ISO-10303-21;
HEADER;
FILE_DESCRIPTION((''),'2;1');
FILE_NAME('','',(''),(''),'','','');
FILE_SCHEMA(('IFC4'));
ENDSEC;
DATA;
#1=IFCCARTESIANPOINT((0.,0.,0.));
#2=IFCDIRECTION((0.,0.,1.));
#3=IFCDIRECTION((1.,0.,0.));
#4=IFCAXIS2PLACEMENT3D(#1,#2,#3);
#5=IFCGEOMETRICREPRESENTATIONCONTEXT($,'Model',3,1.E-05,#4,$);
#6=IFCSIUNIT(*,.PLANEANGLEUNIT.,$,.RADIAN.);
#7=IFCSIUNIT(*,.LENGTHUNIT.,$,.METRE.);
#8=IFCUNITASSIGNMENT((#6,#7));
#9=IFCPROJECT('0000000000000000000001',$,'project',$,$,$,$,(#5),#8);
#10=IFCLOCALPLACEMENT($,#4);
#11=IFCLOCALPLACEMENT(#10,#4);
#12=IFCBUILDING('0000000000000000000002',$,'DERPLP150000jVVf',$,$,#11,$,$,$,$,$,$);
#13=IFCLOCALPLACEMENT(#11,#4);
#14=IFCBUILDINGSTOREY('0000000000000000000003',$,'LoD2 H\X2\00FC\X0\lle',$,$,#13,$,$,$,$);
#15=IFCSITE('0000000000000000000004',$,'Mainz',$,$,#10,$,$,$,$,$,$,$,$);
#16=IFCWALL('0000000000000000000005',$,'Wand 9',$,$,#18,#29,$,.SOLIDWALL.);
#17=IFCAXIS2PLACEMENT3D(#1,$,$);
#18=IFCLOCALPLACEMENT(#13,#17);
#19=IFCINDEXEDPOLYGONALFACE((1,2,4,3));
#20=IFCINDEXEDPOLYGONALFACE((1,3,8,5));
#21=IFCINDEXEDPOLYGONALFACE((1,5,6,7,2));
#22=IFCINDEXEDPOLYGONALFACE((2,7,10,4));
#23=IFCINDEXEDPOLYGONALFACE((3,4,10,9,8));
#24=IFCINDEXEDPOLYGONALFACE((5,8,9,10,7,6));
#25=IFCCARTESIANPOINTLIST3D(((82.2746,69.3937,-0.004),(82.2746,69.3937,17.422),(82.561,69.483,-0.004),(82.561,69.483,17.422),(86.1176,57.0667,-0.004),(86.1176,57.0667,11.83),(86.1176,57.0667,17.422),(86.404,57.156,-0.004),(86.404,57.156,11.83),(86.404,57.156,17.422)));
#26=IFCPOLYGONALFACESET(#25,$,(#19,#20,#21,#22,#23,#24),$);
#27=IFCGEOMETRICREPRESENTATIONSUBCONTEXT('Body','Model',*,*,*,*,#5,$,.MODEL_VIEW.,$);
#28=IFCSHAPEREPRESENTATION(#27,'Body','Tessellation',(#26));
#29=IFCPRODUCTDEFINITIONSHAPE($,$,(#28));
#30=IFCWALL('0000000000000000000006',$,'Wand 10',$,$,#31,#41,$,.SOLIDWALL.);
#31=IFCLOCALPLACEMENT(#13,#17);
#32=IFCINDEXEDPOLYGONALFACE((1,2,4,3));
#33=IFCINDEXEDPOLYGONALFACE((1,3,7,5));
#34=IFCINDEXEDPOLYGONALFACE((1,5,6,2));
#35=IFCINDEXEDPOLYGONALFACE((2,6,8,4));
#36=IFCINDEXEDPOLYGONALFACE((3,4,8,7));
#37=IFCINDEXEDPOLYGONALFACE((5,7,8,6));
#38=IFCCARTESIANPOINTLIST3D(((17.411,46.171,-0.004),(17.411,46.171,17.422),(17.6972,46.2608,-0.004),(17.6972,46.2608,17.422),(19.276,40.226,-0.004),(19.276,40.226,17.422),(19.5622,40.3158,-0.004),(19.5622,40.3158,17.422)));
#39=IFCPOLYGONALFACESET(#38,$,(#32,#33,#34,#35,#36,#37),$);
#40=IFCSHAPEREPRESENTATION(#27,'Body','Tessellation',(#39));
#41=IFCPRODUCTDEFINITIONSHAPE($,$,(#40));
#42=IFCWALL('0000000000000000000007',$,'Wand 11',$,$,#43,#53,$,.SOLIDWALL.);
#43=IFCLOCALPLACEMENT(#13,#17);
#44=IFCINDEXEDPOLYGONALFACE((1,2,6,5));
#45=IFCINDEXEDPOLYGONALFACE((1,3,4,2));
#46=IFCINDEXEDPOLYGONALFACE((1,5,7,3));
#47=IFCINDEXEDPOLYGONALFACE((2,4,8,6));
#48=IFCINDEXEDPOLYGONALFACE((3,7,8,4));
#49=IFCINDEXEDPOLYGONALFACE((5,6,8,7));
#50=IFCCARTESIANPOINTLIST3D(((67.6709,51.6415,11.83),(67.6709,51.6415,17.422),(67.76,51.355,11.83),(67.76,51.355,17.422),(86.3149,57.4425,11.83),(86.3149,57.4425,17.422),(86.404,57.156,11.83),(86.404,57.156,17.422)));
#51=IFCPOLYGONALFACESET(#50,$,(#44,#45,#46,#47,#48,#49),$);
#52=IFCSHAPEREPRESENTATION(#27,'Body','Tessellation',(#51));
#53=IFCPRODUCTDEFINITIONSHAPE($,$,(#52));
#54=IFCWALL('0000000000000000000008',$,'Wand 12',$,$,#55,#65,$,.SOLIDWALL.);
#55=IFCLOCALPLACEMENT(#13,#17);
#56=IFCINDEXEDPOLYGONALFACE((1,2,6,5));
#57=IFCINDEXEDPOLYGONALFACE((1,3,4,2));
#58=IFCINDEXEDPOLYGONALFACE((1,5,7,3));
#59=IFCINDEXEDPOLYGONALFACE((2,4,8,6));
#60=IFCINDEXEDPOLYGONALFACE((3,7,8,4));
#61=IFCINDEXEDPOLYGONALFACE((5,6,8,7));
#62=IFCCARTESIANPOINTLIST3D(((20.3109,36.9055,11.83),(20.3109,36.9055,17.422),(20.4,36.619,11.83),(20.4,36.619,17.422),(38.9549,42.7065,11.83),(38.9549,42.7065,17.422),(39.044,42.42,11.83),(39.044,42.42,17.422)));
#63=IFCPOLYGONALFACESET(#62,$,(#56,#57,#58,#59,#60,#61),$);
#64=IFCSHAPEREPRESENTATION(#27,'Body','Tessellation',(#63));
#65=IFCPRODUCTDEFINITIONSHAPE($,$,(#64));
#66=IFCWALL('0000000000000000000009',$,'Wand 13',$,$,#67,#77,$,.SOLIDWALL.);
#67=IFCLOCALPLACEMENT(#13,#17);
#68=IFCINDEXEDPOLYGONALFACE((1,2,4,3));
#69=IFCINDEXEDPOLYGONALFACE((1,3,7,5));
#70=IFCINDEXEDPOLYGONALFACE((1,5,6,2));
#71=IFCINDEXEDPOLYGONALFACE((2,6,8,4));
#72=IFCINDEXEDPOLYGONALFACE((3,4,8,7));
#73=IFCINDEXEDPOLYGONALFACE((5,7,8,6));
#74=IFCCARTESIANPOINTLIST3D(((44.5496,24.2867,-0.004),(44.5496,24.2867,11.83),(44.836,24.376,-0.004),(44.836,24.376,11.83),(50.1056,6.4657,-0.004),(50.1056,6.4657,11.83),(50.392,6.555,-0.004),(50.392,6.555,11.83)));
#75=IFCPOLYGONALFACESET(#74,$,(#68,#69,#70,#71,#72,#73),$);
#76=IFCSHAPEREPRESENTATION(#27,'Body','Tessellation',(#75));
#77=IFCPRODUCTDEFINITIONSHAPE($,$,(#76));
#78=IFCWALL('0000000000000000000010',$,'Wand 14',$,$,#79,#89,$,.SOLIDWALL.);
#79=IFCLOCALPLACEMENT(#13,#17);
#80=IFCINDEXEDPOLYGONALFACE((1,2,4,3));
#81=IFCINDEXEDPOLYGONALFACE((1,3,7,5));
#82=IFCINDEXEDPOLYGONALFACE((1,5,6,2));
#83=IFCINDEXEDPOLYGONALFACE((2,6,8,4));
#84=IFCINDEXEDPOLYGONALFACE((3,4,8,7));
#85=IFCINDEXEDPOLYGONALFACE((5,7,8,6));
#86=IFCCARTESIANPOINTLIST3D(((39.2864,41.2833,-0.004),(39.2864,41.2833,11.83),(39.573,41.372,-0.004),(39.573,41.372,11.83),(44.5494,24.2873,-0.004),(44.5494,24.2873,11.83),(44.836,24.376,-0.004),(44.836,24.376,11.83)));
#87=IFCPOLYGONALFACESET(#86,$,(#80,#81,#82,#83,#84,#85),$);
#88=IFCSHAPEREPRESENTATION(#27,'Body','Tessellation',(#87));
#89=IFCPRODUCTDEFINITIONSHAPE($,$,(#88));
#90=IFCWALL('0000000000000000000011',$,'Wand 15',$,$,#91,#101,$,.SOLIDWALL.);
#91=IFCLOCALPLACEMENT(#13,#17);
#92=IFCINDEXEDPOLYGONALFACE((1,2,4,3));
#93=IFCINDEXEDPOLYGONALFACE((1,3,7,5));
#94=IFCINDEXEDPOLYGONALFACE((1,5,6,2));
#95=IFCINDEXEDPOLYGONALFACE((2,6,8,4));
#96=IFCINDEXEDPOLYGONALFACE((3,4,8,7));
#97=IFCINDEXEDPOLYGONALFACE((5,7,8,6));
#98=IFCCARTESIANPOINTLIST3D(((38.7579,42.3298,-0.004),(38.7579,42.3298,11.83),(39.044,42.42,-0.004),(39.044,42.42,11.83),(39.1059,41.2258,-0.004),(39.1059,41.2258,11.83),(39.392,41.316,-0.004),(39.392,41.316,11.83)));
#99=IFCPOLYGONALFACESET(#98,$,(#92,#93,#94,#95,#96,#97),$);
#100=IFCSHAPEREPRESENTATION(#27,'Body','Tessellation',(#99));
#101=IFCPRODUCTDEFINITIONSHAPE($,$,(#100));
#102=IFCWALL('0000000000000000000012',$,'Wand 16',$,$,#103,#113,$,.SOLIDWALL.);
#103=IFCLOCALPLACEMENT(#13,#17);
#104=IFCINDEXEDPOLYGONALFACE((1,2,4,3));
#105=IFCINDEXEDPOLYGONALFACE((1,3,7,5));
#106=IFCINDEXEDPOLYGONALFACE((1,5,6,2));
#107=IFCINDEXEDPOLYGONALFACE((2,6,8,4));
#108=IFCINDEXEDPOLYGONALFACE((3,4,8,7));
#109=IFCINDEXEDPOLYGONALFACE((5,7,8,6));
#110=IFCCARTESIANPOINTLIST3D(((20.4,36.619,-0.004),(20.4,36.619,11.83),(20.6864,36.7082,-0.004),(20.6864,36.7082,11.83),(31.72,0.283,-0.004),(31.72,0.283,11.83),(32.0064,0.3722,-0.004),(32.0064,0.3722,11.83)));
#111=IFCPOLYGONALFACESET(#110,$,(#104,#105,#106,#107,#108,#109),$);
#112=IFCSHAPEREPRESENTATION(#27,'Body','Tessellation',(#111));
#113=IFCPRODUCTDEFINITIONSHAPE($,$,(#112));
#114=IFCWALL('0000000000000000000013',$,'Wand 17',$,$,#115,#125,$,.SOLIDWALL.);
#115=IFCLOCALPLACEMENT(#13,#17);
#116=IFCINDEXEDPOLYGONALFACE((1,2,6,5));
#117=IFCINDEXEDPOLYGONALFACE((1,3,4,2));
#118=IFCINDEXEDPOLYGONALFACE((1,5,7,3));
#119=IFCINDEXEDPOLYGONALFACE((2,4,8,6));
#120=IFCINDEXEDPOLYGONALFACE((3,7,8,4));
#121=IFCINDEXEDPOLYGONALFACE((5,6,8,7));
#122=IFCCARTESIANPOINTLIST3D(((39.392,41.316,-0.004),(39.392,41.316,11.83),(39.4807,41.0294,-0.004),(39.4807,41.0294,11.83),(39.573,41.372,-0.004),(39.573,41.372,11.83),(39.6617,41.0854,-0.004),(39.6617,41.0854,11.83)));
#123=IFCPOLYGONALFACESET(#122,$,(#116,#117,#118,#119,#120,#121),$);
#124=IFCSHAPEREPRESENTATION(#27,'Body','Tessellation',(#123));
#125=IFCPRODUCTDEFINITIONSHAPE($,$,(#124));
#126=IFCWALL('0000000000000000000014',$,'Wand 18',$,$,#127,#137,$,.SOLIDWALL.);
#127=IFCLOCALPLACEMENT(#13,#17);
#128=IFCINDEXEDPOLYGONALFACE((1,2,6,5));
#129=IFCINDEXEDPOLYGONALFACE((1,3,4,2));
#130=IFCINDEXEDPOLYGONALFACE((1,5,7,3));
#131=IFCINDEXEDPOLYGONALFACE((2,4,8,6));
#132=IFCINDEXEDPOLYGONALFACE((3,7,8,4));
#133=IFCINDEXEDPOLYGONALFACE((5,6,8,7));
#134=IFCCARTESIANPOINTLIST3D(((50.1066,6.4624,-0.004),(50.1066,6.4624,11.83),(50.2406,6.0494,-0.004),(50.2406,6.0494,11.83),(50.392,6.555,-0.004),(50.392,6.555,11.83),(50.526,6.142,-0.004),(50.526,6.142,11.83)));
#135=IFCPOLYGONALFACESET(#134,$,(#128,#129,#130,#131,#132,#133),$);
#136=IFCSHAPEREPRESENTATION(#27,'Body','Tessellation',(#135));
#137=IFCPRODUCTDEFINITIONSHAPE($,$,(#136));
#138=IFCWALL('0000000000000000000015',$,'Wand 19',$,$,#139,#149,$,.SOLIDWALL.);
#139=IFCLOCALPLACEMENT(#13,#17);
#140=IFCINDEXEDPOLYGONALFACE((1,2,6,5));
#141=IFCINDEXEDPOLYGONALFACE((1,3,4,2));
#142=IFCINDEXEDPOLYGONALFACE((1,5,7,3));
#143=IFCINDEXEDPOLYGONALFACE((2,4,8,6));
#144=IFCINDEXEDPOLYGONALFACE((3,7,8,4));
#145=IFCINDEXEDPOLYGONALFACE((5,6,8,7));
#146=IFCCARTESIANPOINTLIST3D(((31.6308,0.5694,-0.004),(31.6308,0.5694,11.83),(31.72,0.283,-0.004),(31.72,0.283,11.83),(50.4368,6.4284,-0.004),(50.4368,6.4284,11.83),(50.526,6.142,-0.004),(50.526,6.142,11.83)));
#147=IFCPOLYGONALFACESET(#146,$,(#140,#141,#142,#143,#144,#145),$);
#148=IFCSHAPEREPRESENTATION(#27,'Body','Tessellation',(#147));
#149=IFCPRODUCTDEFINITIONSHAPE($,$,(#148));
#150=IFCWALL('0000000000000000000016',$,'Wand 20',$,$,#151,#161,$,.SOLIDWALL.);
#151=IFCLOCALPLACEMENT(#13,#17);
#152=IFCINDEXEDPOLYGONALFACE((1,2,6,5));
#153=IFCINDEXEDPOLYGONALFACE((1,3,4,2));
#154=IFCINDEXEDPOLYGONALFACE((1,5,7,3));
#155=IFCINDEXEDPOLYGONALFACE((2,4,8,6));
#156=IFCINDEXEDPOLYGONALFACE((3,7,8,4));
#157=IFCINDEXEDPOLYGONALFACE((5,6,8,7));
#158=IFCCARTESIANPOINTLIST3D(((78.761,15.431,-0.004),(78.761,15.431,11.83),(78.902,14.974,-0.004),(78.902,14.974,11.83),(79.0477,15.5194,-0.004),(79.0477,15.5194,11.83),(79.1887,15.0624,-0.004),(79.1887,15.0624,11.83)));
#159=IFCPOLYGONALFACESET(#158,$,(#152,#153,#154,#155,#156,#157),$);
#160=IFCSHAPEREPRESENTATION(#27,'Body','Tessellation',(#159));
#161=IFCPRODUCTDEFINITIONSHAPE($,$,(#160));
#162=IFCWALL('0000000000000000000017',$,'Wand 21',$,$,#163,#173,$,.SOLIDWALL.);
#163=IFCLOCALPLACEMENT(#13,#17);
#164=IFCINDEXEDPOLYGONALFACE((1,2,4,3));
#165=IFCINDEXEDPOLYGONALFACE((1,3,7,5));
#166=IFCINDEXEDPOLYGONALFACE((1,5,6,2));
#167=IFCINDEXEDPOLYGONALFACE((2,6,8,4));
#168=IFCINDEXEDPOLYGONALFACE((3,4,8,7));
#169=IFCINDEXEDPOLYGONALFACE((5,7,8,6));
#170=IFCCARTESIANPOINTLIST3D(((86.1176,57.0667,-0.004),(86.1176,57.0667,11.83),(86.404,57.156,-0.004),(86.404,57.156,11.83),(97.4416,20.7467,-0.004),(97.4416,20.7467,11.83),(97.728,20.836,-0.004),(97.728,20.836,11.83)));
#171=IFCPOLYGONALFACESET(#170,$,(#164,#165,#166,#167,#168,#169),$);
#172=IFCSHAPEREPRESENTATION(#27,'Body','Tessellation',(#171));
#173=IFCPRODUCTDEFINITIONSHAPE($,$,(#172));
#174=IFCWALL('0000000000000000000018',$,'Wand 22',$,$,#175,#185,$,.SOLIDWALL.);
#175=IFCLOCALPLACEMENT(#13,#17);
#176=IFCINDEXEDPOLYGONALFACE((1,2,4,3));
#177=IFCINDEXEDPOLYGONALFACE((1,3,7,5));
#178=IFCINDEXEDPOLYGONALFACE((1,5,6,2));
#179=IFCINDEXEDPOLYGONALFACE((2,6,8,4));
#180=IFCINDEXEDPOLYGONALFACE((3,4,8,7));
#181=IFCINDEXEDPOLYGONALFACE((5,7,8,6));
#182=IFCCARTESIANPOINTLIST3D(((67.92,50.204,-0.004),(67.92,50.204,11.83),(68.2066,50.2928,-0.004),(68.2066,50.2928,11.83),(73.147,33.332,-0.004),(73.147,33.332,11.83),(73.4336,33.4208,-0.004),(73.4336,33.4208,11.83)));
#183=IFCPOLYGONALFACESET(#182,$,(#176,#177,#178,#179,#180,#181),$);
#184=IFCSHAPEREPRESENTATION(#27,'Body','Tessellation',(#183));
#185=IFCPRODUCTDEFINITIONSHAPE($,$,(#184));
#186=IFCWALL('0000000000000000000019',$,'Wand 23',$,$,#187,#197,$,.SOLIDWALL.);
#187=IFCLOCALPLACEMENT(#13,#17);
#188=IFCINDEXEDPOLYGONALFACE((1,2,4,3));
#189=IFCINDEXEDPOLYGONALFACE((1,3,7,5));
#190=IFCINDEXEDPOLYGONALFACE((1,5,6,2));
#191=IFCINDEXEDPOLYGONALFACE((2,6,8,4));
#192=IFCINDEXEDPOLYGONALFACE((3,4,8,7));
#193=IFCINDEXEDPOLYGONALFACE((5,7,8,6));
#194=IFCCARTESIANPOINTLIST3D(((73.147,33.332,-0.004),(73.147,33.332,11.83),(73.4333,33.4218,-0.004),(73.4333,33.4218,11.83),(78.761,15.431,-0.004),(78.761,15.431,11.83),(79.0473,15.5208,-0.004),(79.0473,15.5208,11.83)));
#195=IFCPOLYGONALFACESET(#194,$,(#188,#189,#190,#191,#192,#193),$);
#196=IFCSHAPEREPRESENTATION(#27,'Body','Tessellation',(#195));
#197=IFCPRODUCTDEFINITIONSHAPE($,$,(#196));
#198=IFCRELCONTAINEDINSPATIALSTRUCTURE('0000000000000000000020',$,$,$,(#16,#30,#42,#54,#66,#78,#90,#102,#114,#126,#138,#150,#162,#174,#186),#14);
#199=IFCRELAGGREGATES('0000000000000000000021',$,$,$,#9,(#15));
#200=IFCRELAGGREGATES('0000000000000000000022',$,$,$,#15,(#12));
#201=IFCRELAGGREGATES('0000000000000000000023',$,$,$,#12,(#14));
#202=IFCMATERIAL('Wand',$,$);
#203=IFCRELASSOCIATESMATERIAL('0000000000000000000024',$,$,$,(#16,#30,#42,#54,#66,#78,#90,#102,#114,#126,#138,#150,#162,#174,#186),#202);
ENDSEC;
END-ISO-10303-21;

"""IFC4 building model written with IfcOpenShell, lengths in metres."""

from ifc_helpers import new_model, si_unit, frame, origin_with_axes, place, context, subcontext, project, spatial, polyline, outline, extrude, material, element, save


model = new_model("IFC4")

# Units and contexts
model_context = context("Model", 3, precision=1e-05, world=origin_with_axes())
body_context = subcontext(model_context, "Body", "Model", "MODEL_VIEW")
ifc_project = project(units=[si_unit("PLANEANGLEUNIT", "RADIAN"), si_unit("LENGTHUNIT", "METRE")], contexts=[model_context])

# Site, building, storey
site_placement = place(None, origin_with_axes())
site = spatial("IfcSite", under=ifc_project, at=site_placement, Name="Mainz")
building_placement = place(site_placement, origin_with_axes())
building = spatial("IfcBuilding", under=site, at=building_placement, Name="DERPLP150000jVVf")
storey_placement = place(building_placement, origin_with_axes())
storey = spatial("IfcBuildingStorey", under=building, at=storey_placement, Name="LoD2 Hülle")

# Walls
ifc_material_1 = material(Name="Wand")
wall_1_placement = place(storey_placement, origin_with_axes())
element("IfcWall", 1, at=wall_1_placement, inside=storey, material=ifc_material_1, Name="Wand 9", PredefinedType="SOLIDWALL", context=body_context, shape_type="SweptSolid", body=[
    extrude(outline(polyline([(0.0, 0.0), (12.9121, 0.0), (12.9121, 5.592), (12.9121, 17.426), (0.0, 17.426), (0.0, 0.0)])), frame((82.561, 69.483, 17.422), z_axis=(0.954682, 0.297627, 0.0), x_axis=(0.297627, -0.954682, 0.0)), (0.0, 0.0, -1.0), 0.3),
])
wall_2_placement = place(storey_placement, origin_with_axes())
element("IfcWall", 2, at=wall_2_placement, inside=storey, material=ifc_material_1, Name="Wand 10", PredefinedType="SOLIDWALL", context=body_context, shape_type="SweptSolid", body=[
    extrude(outline(polyline([(0.0, 0.0), (6.2307, 0.0), (6.2307, 17.426), (0.0, 17.426), (0.0, 0.0)])), frame((19.276, 40.226, 17.422), z_axis=(-0.954151, -0.299326, 0.0), x_axis=(-0.299326, 0.954151, 0.0)), (0.0, 0.0, -1.0), 0.3),
])
wall_3_placement = place(storey_placement, origin_with_axes())
element("IfcWall", 3, at=wall_3_placement, inside=storey, material=ifc_material_1, Name="Wand 11", PredefinedType="SOLIDWALL", context=body_context, shape_type="SweptSolid", body=[
    extrude(outline(polyline([(0.0, 0.0), (19.5256, 0.0), (19.5256, 5.592), (0.0, 5.592), (0.0, 0.0)])), frame((67.76, 51.355, 11.83), z_axis=(0.297097, -0.954847, 0.0), x_axis=(0.954847, 0.297097, 0.0)), (0.0, 0.0, -1.0), 0.3),
])
wall_4_placement = place(storey_placement, origin_with_axes())
element("IfcWall", 4, at=wall_4_placement, inside=storey, material=ifc_material_1, Name="Wand 12", PredefinedType="SOLIDWALL", context=body_context, shape_type="SweptSolid", body=[
    extrude(outline(polyline([(0.0, 0.0), (19.5256, 0.0), (19.5256, 5.592), (0.0, 5.592), (0.0, 0.0)])), frame((20.4, 36.619, 11.83), z_axis=(0.297097, -0.954847, 0.0), x_axis=(0.954847, 0.297097, 0.0)), (0.0, 0.0, -1.0), 0.3),
])
wall_5_placement = place(storey_placement, origin_with_axes())
element("IfcWall", 5, at=wall_5_placement, inside=storey, material=ifc_material_1, Name="Wand 13", PredefinedType="SOLIDWALL", context=body_context, shape_type="SweptSolid", body=[
    extrude(outline(polyline([(0.0, 0.0), (18.667, 0.0), (18.667, 11.834), (0.0, 11.834), (0.0, 0.0)])), frame((44.836, 24.376, 11.83), z_axis=(0.954679, 0.297637, 0.0), x_axis=(0.297637, -0.954679, 0.0)), (0.0, 0.0, -1.0), 0.3),
])
wall_6_placement = place(storey_placement, origin_with_axes())
element("IfcWall", 6, at=wall_6_placement, inside=storey, material=ifc_material_1, Name="Wand 14", PredefinedType="SOLIDWALL", context=body_context, shape_type="SweptSolid", body=[
    extrude(outline(polyline([(0.0, 0.0), (17.7922, 0.0), (17.7922, 11.834), (0.0, 11.834), (0.0, 0.0)])), frame((39.573, 41.372, 11.83), z_axis=(0.955249, 0.295803, 0.0), x_axis=(0.295803, -0.955249, 0.0)), (0.0, 0.0, -1.0), 0.3),
])
wall_7_placement = place(storey_placement, origin_with_axes())
element("IfcWall", 7, at=wall_7_placement, inside=storey, material=ifc_material_1, Name="Wand 15", PredefinedType="SOLIDWALL", context=body_context, shape_type="SweptSolid", body=[
    extrude(outline(polyline([(0.0, 0.0), (1.1575, 0.0), (1.1575, 11.834), (0.0, 11.834), (0.0, 0.0)])), frame((39.044, 42.42, 11.83), z_axis=(0.953739, 0.300635, 0.0), x_axis=(0.300635, -0.953739, 0.0)), (0.0, 0.0, -1.0), 0.3),
])
wall_8_placement = place(storey_placement, origin_with_axes())
element("IfcWall", 8, at=wall_8_placement, inside=storey, material=ifc_material_1, Name="Wand 16", PredefinedType="SOLIDWALL", context=body_context, shape_type="SweptSolid", body=[
    extrude(outline(polyline([(0.0, 0.0), (38.0585, 0.0), (38.0585, 11.834), (0.0, 11.834), (0.0, 0.0)])), frame((31.72, 0.283, 11.83), z_axis=(-0.954741, -0.297437, 0.0), x_axis=(-0.297437, 0.954741, 0.0)), (0.0, 0.0, -1.0), 0.3),
])
wall_9_placement = place(storey_placement, origin_with_axes())
element("IfcWall", 9, at=wall_9_placement, inside=storey, material=ifc_material_1, Name="Wand 17", PredefinedType="SOLIDWALL", context=body_context, shape_type="SweptSolid", body=[
    extrude(outline(polyline([(0.0, 0.0), (0.1895, 0.0), (0.1895, 11.834), (0.0, 11.834), (0.0, 0.0)])), frame((39.392, 41.316, 11.83), z_axis=(-0.295569, 0.955321, 0.0), x_axis=(0.955321, 0.295569, 0.0)), (0.0, 0.0, -1.0), 0.3),
])
wall_10_placement = place(storey_placement, origin_with_axes())
element("IfcWall", 10, at=wall_10_placement, inside=storey, material=ifc_material_1, Name="Wand 18", PredefinedType="SOLIDWALL", context=body_context, shape_type="SweptSolid", body=[
    extrude(outline(polyline([(0.0, 0.0), (0.4342, 0.0), (0.4342, 11.834), (0.0, 11.834), (0.0, 0.0)])), frame((50.392, 6.555, 11.83), z_axis=(0.951186, 0.308617, 0.0), x_axis=(0.308617, -0.951186, 0.0)), (0.0, 0.0, -1.0), 0.3),
])
wall_11_placement = place(storey_placement, origin_with_axes())
element("IfcWall", 11, at=wall_11_placement, inside=storey, material=ifc_material_1, Name="Wand 19", PredefinedType="SOLIDWALL", context=body_context, shape_type="SweptSolid", body=[
    extrude(outline(polyline([(0.0, 0.0), (19.6976, 0.0), (19.6976, 11.834), (0.0, 11.834), (0.0, 0.0)])), frame((50.526, 6.142, 11.83), z_axis=(0.297448, -0.954738, 0.0), x_axis=(-0.954738, -0.297448, 0.0)), (0.0, 0.0, -1.0), 0.3),
])
wall_12_placement = place(storey_placement, origin_with_axes())
element("IfcWall", 12, at=wall_12_placement, inside=storey, material=ifc_material_1, Name="Wand 20", PredefinedType="SOLIDWALL", context=body_context, shape_type="SweptSolid", body=[
    extrude(outline(polyline([(0.0, 0.0), (0.4783, 0.0), (0.4783, 11.834), (0.0, 11.834), (0.0, 0.0)])), frame((78.902, 14.974, 11.83), z_axis=(-0.955553, -0.29482, 0.0), x_axis=(-0.29482, 0.955553, 0.0)), (0.0, 0.0, -1.0), 0.3),
])
wall_13_placement = place(storey_placement, origin_with_axes())
element("IfcWall", 13, at=wall_13_placement, inside=storey, material=ifc_material_1, Name="Wand 21", PredefinedType="SOLIDWALL", context=body_context, shape_type="SweptSolid", body=[
    extrude(outline(polyline([(0.0, 0.0), (38.0444, 0.0), (38.0444, 11.834), (0.0, 11.834), (0.0, 0.0)])), frame((86.404, 57.156, 11.83), z_axis=(0.954674, 0.297652, 0.0), x_axis=(0.297652, -0.954674, 0.0)), (0.0, 0.0, -1.0), 0.3),
])
wall_14_placement = place(storey_placement, origin_with_axes())
element("IfcWall", 14, at=wall_14_placement, inside=storey, material=ifc_material_1, Name="Wand 22", PredefinedType="SOLIDWALL", context=body_context, shape_type="SweptSolid", body=[
    extrude(outline(polyline([(0.0, 0.0), (17.6631, 0.0), (17.6631, 11.834), (0.0, 11.834), (0.0, 0.0)])), frame((73.147, 33.332, 11.83), z_axis=(-0.95521, -0.295927, 0.0), x_axis=(-0.295927, 0.95521, 0.0)), (0.0, 0.0, -1.0), 0.3),
])
wall_15_placement = place(storey_placement, origin_with_axes())
element("IfcWall", 15, at=wall_15_placement, inside=storey, material=ifc_material_1, Name="Wand 23", PredefinedType="SOLIDWALL", context=body_context, shape_type="SweptSolid", body=[
    extrude(outline(polyline([(0.0, 0.0), (18.7607, 0.0), (18.7607, 11.834), (0.0, 11.834), (0.0, 0.0)])), frame((78.761, 15.431, 11.83), z_axis=(-0.954177, -0.299243, 0.0), x_axis=(-0.299243, 0.954177, 0.0)), (0.0, 0.0, -1.0), 0.3),
])

save(model, "model.ifc")
